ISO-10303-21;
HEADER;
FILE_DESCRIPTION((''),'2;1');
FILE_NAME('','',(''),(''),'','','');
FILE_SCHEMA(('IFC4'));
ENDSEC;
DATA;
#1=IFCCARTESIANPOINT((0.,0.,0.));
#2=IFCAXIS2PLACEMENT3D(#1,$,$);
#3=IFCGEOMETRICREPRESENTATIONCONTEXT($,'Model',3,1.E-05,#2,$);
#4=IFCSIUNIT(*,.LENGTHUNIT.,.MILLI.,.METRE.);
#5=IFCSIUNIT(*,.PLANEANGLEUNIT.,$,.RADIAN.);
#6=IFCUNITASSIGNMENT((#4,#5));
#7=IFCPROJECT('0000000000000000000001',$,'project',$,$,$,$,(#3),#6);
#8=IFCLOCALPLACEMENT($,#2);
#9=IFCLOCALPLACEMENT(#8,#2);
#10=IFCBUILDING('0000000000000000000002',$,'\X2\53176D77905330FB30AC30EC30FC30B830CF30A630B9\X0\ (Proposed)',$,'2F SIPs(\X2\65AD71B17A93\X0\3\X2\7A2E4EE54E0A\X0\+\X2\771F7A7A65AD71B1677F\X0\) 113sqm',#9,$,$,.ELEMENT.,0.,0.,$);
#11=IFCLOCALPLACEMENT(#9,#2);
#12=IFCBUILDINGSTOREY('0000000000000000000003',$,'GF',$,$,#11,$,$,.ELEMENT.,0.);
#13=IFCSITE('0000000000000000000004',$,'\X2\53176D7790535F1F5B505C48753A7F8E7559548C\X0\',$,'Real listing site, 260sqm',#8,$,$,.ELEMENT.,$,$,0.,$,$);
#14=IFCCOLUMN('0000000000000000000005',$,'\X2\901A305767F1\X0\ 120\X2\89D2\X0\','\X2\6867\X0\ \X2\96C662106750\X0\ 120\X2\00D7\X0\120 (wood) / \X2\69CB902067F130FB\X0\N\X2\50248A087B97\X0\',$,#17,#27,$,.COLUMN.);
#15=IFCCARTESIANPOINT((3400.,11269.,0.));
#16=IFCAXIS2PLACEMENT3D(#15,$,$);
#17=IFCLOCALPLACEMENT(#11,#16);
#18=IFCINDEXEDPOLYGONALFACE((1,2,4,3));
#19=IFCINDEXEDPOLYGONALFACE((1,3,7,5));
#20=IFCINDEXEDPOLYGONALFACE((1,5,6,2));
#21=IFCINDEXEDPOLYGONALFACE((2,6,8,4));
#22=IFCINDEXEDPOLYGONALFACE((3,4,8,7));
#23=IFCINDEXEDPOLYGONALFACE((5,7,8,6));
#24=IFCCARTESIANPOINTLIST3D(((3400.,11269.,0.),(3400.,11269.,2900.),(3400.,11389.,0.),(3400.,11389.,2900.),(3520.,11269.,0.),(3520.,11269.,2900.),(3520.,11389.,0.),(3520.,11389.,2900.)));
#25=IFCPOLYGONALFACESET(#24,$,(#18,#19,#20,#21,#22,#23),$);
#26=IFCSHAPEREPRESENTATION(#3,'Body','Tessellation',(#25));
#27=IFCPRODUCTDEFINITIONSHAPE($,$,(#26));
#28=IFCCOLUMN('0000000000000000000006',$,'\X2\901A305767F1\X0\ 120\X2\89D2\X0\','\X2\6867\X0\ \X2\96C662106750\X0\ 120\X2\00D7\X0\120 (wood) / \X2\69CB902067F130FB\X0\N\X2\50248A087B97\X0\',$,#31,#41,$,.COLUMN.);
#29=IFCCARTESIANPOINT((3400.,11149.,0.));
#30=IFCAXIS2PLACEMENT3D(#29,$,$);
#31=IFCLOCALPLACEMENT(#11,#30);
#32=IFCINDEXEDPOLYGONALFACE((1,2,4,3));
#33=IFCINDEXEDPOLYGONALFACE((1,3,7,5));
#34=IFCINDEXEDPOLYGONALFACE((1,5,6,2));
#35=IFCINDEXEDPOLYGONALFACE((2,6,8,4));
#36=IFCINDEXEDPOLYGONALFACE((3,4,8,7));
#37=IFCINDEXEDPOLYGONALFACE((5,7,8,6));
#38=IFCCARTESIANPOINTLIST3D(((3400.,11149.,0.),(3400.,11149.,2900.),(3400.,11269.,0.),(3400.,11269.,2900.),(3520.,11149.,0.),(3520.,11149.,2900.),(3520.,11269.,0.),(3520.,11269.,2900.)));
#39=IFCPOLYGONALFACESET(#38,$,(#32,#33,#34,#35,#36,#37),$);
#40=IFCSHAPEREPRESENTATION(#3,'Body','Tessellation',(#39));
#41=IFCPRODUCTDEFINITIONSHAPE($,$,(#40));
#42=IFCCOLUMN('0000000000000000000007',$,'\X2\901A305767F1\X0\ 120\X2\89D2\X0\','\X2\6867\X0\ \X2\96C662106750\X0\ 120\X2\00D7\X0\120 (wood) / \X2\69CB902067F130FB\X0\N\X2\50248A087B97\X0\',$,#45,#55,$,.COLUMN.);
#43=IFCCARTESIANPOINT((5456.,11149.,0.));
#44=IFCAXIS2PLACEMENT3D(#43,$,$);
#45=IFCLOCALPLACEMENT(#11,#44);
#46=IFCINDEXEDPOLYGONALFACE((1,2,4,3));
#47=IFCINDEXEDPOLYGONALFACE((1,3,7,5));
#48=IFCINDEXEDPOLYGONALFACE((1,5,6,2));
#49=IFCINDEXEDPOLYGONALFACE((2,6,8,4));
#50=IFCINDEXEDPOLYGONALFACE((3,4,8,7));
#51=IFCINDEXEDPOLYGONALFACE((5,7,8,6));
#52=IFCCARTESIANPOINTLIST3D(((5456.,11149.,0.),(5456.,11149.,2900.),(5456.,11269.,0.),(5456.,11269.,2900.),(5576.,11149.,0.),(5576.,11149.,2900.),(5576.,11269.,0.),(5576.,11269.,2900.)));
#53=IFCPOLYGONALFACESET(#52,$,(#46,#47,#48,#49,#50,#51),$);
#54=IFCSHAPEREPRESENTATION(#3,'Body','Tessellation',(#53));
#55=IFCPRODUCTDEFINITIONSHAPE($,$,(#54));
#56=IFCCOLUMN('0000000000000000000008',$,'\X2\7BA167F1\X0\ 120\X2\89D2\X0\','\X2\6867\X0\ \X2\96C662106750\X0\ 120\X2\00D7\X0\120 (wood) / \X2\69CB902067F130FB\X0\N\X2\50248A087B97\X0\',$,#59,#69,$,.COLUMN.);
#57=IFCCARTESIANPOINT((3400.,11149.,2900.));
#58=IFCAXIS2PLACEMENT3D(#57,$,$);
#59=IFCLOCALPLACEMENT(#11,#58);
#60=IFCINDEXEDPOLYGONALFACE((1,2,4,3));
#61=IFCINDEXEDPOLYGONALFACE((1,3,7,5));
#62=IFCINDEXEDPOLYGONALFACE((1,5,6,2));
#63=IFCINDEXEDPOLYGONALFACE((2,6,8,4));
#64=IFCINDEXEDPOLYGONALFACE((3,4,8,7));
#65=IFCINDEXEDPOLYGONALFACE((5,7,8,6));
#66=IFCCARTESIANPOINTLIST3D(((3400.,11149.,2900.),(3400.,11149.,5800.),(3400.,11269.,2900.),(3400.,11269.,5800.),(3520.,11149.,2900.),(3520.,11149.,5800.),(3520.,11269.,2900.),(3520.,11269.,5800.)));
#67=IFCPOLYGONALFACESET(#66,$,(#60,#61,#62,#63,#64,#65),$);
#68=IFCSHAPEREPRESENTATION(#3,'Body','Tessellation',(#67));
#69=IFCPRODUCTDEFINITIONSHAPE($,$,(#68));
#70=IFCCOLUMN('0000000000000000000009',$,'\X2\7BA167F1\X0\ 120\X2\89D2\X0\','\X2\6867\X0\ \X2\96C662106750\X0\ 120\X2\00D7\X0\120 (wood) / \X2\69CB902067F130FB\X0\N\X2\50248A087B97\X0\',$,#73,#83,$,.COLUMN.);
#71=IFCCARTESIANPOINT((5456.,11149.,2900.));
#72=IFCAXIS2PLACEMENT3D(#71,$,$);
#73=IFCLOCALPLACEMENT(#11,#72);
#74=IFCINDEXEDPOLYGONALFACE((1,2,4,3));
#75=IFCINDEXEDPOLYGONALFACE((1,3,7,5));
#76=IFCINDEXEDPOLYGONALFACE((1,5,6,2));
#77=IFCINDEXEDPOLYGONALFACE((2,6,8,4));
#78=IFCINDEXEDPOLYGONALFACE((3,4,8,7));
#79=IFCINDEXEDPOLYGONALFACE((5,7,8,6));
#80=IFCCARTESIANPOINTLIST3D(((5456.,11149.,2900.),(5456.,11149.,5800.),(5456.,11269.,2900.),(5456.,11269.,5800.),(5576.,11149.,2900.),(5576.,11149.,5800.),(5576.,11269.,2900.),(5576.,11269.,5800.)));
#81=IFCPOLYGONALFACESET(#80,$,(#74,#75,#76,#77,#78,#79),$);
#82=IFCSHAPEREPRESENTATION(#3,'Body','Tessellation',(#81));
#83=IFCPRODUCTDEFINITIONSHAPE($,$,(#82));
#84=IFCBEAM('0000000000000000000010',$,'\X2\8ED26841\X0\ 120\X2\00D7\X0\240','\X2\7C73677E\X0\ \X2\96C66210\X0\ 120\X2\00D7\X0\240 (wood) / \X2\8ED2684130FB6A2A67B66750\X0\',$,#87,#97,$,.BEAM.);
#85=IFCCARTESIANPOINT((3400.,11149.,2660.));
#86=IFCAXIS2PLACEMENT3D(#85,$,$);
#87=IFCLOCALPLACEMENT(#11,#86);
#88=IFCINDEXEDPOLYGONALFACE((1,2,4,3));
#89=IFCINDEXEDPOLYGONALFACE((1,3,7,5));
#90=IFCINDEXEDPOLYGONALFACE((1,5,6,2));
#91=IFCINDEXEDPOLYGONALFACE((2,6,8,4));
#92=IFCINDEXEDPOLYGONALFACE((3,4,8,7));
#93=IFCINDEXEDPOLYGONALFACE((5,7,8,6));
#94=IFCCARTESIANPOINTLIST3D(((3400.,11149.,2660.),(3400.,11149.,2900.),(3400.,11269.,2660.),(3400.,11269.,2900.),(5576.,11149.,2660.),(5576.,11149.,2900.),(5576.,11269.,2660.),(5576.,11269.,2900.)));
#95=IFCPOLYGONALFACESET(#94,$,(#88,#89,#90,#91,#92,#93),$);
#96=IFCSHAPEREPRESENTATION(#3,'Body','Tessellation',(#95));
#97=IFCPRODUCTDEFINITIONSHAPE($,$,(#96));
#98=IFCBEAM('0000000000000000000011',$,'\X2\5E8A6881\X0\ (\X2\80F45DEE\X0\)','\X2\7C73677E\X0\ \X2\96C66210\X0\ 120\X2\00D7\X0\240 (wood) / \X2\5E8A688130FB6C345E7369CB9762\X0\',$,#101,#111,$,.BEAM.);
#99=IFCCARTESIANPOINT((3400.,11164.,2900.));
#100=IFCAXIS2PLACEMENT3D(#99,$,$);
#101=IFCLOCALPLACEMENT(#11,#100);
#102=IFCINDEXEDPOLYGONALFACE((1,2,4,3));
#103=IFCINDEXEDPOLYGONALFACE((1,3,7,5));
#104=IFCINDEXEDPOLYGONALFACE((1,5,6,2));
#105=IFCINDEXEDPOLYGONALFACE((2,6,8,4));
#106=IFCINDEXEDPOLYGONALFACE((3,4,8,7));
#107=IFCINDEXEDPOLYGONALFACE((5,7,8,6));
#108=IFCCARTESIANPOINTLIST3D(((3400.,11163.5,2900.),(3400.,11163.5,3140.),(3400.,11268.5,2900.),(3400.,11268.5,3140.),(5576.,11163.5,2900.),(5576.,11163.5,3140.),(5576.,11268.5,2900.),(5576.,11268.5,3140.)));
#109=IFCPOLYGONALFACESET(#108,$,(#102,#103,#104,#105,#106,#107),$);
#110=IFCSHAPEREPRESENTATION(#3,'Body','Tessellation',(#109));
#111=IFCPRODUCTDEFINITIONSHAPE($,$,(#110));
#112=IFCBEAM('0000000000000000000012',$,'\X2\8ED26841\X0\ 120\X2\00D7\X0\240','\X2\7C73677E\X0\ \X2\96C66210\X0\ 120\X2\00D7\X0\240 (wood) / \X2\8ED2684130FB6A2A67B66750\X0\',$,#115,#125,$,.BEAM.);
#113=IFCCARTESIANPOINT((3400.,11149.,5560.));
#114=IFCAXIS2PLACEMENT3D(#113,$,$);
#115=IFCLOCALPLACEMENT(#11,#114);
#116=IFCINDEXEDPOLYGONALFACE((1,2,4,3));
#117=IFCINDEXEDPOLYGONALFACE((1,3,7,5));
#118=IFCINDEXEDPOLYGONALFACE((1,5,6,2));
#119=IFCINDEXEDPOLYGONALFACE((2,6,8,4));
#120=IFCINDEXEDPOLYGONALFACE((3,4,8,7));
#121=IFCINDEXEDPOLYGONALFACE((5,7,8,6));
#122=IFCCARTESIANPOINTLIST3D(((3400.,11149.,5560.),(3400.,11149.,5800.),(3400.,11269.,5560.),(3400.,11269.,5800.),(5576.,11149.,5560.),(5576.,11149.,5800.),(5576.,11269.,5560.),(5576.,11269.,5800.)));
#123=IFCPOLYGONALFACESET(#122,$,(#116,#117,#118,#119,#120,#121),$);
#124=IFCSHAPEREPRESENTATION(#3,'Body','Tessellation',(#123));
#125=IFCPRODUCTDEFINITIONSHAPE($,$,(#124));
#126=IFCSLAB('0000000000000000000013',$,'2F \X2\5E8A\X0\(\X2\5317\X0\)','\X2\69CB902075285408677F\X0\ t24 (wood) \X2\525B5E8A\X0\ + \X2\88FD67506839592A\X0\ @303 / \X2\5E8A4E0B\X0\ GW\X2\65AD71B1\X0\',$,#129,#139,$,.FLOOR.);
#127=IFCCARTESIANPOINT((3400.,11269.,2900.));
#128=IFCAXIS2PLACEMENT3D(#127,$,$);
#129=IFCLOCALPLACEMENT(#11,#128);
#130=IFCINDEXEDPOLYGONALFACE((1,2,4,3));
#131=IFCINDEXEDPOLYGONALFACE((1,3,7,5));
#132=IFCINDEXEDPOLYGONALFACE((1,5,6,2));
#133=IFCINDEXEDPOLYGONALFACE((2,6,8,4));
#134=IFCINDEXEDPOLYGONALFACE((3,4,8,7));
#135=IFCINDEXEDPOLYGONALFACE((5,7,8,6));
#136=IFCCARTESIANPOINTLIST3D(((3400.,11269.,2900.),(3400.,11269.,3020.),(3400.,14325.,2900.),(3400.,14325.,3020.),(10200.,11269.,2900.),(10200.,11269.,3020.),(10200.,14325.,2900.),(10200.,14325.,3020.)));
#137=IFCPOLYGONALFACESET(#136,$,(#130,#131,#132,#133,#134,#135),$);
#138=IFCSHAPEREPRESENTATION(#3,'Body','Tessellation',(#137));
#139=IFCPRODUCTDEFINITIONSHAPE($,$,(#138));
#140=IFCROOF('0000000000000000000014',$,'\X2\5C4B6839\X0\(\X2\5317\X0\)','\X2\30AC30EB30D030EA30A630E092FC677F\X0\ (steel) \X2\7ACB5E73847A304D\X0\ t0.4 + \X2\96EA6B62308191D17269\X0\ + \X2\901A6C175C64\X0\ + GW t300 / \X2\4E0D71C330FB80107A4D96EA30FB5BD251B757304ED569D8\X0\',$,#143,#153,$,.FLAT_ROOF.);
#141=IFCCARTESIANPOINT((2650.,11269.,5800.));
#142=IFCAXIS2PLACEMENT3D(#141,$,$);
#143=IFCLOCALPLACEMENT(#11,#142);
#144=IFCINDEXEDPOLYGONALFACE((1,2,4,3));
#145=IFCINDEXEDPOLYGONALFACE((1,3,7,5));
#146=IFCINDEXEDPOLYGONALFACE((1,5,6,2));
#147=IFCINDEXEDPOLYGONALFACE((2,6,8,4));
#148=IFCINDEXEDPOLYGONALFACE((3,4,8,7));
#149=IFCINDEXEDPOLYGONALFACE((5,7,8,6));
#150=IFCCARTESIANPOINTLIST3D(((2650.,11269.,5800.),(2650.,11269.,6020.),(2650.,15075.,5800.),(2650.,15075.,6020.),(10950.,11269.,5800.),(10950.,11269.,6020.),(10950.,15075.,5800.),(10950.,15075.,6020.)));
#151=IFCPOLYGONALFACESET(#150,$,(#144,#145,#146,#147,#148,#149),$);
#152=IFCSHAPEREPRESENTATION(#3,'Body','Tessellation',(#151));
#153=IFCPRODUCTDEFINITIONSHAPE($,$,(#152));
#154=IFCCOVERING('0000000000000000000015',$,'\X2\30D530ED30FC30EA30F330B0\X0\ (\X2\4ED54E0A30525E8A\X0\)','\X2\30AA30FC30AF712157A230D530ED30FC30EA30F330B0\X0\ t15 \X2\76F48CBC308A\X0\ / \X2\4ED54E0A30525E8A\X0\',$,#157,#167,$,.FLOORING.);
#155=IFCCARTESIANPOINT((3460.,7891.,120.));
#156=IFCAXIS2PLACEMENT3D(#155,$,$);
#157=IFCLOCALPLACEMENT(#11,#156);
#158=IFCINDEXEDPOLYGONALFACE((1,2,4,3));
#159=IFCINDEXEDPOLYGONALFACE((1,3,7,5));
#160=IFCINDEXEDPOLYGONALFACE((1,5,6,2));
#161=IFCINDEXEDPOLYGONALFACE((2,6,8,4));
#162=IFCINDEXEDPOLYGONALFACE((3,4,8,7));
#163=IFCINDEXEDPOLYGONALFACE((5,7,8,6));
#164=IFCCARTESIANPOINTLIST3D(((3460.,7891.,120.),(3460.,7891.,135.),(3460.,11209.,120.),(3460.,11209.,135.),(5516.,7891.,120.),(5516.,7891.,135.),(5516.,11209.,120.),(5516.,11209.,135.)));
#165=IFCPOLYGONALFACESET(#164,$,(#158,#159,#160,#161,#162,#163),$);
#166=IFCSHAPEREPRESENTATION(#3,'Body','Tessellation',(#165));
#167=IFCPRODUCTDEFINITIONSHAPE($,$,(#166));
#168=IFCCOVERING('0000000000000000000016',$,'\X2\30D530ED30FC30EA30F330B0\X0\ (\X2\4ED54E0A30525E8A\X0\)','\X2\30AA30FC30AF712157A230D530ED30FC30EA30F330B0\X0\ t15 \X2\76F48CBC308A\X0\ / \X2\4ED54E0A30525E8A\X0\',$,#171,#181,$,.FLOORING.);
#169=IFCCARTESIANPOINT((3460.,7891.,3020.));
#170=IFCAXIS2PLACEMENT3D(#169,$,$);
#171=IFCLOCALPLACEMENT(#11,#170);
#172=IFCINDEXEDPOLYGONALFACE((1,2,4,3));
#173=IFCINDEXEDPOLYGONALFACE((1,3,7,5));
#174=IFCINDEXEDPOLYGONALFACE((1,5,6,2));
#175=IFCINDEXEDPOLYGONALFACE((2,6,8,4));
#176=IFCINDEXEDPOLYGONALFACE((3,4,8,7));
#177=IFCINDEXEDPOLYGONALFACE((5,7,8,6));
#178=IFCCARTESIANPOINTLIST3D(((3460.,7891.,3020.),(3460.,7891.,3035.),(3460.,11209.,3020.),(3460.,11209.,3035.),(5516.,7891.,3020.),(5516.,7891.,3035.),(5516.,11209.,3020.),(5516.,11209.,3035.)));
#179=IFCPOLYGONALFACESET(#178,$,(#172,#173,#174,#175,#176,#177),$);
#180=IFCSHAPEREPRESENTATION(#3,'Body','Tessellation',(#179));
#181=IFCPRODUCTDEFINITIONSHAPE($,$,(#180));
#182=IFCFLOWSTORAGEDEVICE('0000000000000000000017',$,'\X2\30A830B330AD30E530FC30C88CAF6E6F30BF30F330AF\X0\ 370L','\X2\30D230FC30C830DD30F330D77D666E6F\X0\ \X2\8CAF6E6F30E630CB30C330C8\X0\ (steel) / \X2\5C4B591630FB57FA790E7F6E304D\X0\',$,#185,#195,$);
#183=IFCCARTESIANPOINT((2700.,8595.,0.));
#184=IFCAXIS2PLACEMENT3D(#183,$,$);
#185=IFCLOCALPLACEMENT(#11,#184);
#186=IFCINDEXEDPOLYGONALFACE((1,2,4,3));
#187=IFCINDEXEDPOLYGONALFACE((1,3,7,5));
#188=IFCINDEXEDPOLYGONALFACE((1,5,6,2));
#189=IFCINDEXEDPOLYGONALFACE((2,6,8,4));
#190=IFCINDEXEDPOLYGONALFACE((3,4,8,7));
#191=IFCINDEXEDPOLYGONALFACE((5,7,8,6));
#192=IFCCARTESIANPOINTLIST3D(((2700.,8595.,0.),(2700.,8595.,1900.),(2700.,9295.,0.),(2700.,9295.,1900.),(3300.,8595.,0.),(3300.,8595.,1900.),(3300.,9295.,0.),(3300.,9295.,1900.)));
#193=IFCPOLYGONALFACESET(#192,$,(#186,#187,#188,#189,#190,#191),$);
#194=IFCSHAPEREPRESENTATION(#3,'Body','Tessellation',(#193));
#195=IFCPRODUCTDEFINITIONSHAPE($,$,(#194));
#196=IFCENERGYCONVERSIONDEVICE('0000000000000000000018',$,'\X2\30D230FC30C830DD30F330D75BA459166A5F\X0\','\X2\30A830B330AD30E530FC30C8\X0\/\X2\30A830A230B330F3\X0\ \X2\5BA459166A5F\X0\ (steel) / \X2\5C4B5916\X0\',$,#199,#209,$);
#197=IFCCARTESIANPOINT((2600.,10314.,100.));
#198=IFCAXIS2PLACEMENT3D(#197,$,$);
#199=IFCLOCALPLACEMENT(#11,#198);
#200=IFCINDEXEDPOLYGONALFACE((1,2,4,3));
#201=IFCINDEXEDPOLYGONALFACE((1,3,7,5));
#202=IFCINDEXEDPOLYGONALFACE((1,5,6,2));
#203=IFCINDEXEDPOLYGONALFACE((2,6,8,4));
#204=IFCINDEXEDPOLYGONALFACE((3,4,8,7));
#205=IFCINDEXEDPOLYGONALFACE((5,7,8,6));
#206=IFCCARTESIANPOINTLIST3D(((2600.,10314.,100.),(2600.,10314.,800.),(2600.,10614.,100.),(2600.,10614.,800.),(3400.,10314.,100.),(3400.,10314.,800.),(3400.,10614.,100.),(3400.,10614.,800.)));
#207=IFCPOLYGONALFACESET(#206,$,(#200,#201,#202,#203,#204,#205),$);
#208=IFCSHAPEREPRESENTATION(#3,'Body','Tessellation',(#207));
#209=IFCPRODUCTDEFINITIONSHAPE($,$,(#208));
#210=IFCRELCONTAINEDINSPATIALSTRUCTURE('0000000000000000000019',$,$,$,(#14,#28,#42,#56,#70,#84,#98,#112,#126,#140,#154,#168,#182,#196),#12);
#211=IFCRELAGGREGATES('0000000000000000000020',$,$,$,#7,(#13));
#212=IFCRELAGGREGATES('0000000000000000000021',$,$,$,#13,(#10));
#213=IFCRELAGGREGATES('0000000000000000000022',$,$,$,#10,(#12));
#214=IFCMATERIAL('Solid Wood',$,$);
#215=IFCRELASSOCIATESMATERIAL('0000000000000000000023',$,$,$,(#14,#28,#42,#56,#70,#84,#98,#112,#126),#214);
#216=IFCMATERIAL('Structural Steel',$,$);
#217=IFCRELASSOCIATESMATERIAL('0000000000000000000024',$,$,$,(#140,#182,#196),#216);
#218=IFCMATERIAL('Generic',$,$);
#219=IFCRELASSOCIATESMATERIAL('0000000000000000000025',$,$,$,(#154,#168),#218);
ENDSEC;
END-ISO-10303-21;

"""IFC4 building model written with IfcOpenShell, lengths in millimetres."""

from ifc_helpers import new_model, si_unit, frame, frame_2d, origin, place, context, project, spatial, rectangle, extrude, material, element, save


model = new_model("IFC4")

# Units and contexts
model_context = context("Model", 3, precision=1e-05, world=origin())
ifc_project = project(units=[si_unit("LENGTHUNIT", "METRE", prefix="MILLI"), si_unit("PLANEANGLEUNIT", "RADIAN")], contexts=[model_context])

# Site, building, storey
site_placement = place(None, origin())
site = spatial("IfcSite", under=ifc_project, at=site_placement, Name="北海道弟子屈町美留和", ObjectType="Real listing site, 260sqm", CompositionType="ELEMENT", RefElevation=0.0)
building_placement = place(site_placement, origin())
building = spatial("IfcBuilding", under=site, at=building_placement, Name="北海道・ガレージハウス (Proposed)", ObjectType="2F SIPs(断熱窓3種以上+真空断熱板) 113sqm", CompositionType="ELEMENT", ElevationOfRefHeight=0.0, ElevationOfTerrain=0.0)
storey_placement = place(building_placement, origin())
storey = spatial("IfcBuildingStorey", under=building, at=storey_placement, Name="GF", CompositionType="ELEMENT", Elevation=0.0)

# Columns
ifc_material_1 = material(Name="Solid Wood")
column_1_placement = place(storey_placement, frame((3400.0, 11269.0, 0.0)))
element("IfcColumn", 1, at=column_1_placement, inside=storey, material=ifc_material_1, Name="通し柱 120角", Description="桧 集成材 120×120 (wood) / 構造柱・N値計算", PredefinedType="COLUMN", context=model_context, shape_type="SweptSolid", body=[
    extrude(rectangle(XDim=120.0, YDim=120.0, at=frame_2d((60.0, 60.0))), frame((3400.0, 11269.0, 0.0)), (0.0, 0.0, 1.0), 2900.0),
])
column_2_placement = place(storey_placement, frame((3400.0, 11149.0, 0.0)))
element("IfcColumn", 2, at=column_2_placement, inside=storey, material=ifc_material_1, Name="通し柱 120角", Description="桧 集成材 120×120 (wood) / 構造柱・N値計算", PredefinedType="COLUMN", context=model_context, shape_type="SweptSolid", body=[
    extrude(rectangle(XDim=120.0, YDim=120.0, at=frame_2d((60.0, 60.0))), frame((3400.0, 11149.0, 0.0)), (0.0, 0.0, 1.0), 2900.0),
])
column_3_placement = place(storey_placement, frame((5456.0, 11149.0, 0.0)))
element("IfcColumn", 3, at=column_3_placement, inside=storey, material=ifc_material_1, Name="通し柱 120角", Description="桧 集成材 120×120 (wood) / 構造柱・N値計算", PredefinedType="COLUMN", context=model_context, shape_type="SweptSolid", body=[
    extrude(rectangle(XDim=120.0, YDim=120.0, at=frame_2d((60.0, 60.0))), frame((5456.0, 11149.0, 0.0)), (0.0, 0.0, 1.0), 2900.0),
])
column_4_placement = place(storey_placement, frame((3400.0, 11149.0, 2900.0)))
element("IfcColumn", 4, at=column_4_placement, inside=storey, material=ifc_material_1, Name="管柱 120角", Description="桧 集成材 120×120 (wood) / 構造柱・N値計算", PredefinedType="COLUMN", context=model_context, shape_type="SweptSolid", body=[
    extrude(rectangle(XDim=120.0, YDim=120.0, at=frame_2d((60.0, 60.0))), frame((3400.0, 11149.0, 2900.0)), (0.0, 0.0, 1.0), 2900.0),
])
column_5_placement = place(storey_placement, frame((5456.0, 11149.0, 2900.0)))
element("IfcColumn", 5, at=column_5_placement, inside=storey, material=ifc_material_1, Name="管柱 120角", Description="桧 集成材 120×120 (wood) / 構造柱・N値計算", PredefinedType="COLUMN", context=model_context, shape_type="SweptSolid", body=[
    extrude(rectangle(XDim=120.0, YDim=120.0, at=frame_2d((60.0, 60.0))), frame((5456.0, 11149.0, 2900.0)), (0.0, 0.0, 1.0), 2900.0),
])

# Beams
beam_1_placement = place(storey_placement, frame((3400.0, 11149.0, 2660.0)))
element("IfcBeam", 6, at=beam_1_placement, inside=storey, material=ifc_material_1, Name="軒桁 120×240", Description="米松 集成 120×240 (wood) / 軒桁・横架材", PredefinedType="BEAM", context=model_context, shape_type="SweptSolid", body=[
    extrude(rectangle(XDim=2176.0, YDim=120.0, at=frame_2d((1088.0, 60.0))), frame((3400.0, 11149.0, 2660.0)), (0.0, 0.0, 1.0), 240.0),
])
beam_2_placement = place(storey_placement, frame((3400.0, 11164.0, 2900.0)))
element("IfcBeam", 7, at=beam_2_placement, inside=storey, material=ifc_material_1, Name="床梁 (胴差)", Description="米松 集成 120×240 (wood) / 床梁・水平構面", PredefinedType="BEAM", context=model_context, shape_type="SweptSolid", body=[
    extrude(rectangle(XDim=2176.0, YDim=105.0, at=frame_2d((1088.0, 52.0))), frame((3400.0, 11164.0, 2900.0)), (0.0, 0.0, 1.0), 240.0),
])
beam_3_placement = place(storey_placement, frame((3400.0, 11149.0, 5560.0)))
element("IfcBeam", 8, at=beam_3_placement, inside=storey, material=ifc_material_1, Name="軒桁 120×240", Description="米松 集成 120×240 (wood) / 軒桁・横架材", PredefinedType="BEAM", context=model_context, shape_type="SweptSolid", body=[
    extrude(rectangle(XDim=2176.0, YDim=120.0, at=frame_2d((1088.0, 60.0))), frame((3400.0, 11149.0, 5560.0)), (0.0, 0.0, 1.0), 240.0),
])

# Slab
slab_1_placement = place(storey_placement, frame((3400.0, 11269.0, 2900.0)))
element("IfcSlab", 9, at=slab_1_placement, inside=storey, material=ifc_material_1, Name="2F 床(北)", Description="構造用合板 t24 (wood) 剛床 + 製材根太 @303 / 床下 GW断熱", PredefinedType="FLOOR", context=model_context, shape_type="SweptSolid", body=[
    extrude(rectangle(XDim=6800.0, YDim=3056.0, at=frame_2d((3400.0, 1528.0))), frame((3400.0, 11269.0, 2900.0)), (0.0, 0.0, 1.0), 120.0),
])

# Roof
ifc_material_2 = material(Name="Structural Steel")
for number, where, name in (
    (10, (2650.0, 11269.0, 5800.0), "屋根(北)"),
):
    element("IfcRoof", number, at=place(storey_placement, frame(where)), inside=storey, material=ifc_material_2, Name=name, Description="ガルバリウム鋼板 (steel) 立平葺き t0.4 + 雪止め金物 + 通気層 + GW t300 / 不燃・耐積雪・寒冷地仕様", PredefinedType="FLAT_ROOF", context=model_context, shape_type="SweptSolid", body=[
        extrude(rectangle(XDim=8300.0, YDim=3806.0, at=frame_2d((4150.0, 1903.0))), frame((2650.0, 11269.0, 5800.0)), (0.0, 0.0, 1.0), 220.0),
    ])

# Coverings
ifc_material_3 = material(Name="Generic")
covering_1_placement = place(storey_placement, frame((3460.0, 7891.0, 120.0)))
element("IfcCovering", 11, at=covering_1_placement, inside=storey, material=ifc_material_3, Name="フローリング (仕上げ床)", Description="オーク無垢フローリング t15 直貼り / 仕上げ床", PredefinedType="FLOORING", context=model_context, shape_type="SweptSolid", body=[
    extrude(rectangle(XDim=2056.0, YDim=3318.0, at=frame_2d((1028.0, 1659.0))), frame((3460.0, 7891.0, 120.0)), (0.0, 0.0, 1.0), 15.0),
])
covering_2_placement = place(storey_placement, frame((3460.0, 7891.0, 3020.0)))
element("IfcCovering", 12, at=covering_2_placement, inside=storey, material=ifc_material_3, Name="フローリング (仕上げ床)", Description="オーク無垢フローリング t15 直貼り / 仕上げ床", PredefinedType="FLOORING", context=model_context, shape_type="SweptSolid", body=[
    extrude(rectangle(XDim=2056.0, YDim=3318.0, at=frame_2d((1028.0, 1659.0))), frame((3460.0, 7891.0, 3020.0)), (0.0, 0.0, 1.0), 15.0),
])

# Flow storage device
flow_storage_device_placement = place(storey_placement, frame((2700.0, 8595.0, 0.0)))
element("IfcFlowStorageDevice", 13, at=flow_storage_device_placement, inside=storey, material=ifc_material_2, Name="エコキュート貯湯タンク 370L", Description="ヒートポンプ給湯 貯湯ユニット (steel) / 屋外・基礎置き", context=model_context, shape_type="SweptSolid", body=[
    extrude(rectangle(XDim=600.0, YDim=700.0, at=frame_2d((300.0, 350.0))), frame((2700.0, 8595.0, 0.0)), (0.0, 0.0, 1.0), 1900.0),
])

# Energy conversion device
energy_conversion_device_placement = place(storey_placement, frame((2600.0, 10314.0, 100.0)))
element("IfcEnergyConversionDevice", 14, at=energy_conversion_device_placement, inside=storey, material=ifc_material_2, Name="ヒートポンプ室外機", Description="エコキュート/エアコン 室外機 (steel) / 屋外", context=model_context, shape_type="SweptSolid", body=[
    extrude(rectangle(XDim=800.0, YDim=300.0, at=frame_2d((400.0, 150.0))), frame((2600.0, 10314.0, 100.0)), (0.0, 0.0, 1.0), 700.0),
])

save(model, "model.ifc")
